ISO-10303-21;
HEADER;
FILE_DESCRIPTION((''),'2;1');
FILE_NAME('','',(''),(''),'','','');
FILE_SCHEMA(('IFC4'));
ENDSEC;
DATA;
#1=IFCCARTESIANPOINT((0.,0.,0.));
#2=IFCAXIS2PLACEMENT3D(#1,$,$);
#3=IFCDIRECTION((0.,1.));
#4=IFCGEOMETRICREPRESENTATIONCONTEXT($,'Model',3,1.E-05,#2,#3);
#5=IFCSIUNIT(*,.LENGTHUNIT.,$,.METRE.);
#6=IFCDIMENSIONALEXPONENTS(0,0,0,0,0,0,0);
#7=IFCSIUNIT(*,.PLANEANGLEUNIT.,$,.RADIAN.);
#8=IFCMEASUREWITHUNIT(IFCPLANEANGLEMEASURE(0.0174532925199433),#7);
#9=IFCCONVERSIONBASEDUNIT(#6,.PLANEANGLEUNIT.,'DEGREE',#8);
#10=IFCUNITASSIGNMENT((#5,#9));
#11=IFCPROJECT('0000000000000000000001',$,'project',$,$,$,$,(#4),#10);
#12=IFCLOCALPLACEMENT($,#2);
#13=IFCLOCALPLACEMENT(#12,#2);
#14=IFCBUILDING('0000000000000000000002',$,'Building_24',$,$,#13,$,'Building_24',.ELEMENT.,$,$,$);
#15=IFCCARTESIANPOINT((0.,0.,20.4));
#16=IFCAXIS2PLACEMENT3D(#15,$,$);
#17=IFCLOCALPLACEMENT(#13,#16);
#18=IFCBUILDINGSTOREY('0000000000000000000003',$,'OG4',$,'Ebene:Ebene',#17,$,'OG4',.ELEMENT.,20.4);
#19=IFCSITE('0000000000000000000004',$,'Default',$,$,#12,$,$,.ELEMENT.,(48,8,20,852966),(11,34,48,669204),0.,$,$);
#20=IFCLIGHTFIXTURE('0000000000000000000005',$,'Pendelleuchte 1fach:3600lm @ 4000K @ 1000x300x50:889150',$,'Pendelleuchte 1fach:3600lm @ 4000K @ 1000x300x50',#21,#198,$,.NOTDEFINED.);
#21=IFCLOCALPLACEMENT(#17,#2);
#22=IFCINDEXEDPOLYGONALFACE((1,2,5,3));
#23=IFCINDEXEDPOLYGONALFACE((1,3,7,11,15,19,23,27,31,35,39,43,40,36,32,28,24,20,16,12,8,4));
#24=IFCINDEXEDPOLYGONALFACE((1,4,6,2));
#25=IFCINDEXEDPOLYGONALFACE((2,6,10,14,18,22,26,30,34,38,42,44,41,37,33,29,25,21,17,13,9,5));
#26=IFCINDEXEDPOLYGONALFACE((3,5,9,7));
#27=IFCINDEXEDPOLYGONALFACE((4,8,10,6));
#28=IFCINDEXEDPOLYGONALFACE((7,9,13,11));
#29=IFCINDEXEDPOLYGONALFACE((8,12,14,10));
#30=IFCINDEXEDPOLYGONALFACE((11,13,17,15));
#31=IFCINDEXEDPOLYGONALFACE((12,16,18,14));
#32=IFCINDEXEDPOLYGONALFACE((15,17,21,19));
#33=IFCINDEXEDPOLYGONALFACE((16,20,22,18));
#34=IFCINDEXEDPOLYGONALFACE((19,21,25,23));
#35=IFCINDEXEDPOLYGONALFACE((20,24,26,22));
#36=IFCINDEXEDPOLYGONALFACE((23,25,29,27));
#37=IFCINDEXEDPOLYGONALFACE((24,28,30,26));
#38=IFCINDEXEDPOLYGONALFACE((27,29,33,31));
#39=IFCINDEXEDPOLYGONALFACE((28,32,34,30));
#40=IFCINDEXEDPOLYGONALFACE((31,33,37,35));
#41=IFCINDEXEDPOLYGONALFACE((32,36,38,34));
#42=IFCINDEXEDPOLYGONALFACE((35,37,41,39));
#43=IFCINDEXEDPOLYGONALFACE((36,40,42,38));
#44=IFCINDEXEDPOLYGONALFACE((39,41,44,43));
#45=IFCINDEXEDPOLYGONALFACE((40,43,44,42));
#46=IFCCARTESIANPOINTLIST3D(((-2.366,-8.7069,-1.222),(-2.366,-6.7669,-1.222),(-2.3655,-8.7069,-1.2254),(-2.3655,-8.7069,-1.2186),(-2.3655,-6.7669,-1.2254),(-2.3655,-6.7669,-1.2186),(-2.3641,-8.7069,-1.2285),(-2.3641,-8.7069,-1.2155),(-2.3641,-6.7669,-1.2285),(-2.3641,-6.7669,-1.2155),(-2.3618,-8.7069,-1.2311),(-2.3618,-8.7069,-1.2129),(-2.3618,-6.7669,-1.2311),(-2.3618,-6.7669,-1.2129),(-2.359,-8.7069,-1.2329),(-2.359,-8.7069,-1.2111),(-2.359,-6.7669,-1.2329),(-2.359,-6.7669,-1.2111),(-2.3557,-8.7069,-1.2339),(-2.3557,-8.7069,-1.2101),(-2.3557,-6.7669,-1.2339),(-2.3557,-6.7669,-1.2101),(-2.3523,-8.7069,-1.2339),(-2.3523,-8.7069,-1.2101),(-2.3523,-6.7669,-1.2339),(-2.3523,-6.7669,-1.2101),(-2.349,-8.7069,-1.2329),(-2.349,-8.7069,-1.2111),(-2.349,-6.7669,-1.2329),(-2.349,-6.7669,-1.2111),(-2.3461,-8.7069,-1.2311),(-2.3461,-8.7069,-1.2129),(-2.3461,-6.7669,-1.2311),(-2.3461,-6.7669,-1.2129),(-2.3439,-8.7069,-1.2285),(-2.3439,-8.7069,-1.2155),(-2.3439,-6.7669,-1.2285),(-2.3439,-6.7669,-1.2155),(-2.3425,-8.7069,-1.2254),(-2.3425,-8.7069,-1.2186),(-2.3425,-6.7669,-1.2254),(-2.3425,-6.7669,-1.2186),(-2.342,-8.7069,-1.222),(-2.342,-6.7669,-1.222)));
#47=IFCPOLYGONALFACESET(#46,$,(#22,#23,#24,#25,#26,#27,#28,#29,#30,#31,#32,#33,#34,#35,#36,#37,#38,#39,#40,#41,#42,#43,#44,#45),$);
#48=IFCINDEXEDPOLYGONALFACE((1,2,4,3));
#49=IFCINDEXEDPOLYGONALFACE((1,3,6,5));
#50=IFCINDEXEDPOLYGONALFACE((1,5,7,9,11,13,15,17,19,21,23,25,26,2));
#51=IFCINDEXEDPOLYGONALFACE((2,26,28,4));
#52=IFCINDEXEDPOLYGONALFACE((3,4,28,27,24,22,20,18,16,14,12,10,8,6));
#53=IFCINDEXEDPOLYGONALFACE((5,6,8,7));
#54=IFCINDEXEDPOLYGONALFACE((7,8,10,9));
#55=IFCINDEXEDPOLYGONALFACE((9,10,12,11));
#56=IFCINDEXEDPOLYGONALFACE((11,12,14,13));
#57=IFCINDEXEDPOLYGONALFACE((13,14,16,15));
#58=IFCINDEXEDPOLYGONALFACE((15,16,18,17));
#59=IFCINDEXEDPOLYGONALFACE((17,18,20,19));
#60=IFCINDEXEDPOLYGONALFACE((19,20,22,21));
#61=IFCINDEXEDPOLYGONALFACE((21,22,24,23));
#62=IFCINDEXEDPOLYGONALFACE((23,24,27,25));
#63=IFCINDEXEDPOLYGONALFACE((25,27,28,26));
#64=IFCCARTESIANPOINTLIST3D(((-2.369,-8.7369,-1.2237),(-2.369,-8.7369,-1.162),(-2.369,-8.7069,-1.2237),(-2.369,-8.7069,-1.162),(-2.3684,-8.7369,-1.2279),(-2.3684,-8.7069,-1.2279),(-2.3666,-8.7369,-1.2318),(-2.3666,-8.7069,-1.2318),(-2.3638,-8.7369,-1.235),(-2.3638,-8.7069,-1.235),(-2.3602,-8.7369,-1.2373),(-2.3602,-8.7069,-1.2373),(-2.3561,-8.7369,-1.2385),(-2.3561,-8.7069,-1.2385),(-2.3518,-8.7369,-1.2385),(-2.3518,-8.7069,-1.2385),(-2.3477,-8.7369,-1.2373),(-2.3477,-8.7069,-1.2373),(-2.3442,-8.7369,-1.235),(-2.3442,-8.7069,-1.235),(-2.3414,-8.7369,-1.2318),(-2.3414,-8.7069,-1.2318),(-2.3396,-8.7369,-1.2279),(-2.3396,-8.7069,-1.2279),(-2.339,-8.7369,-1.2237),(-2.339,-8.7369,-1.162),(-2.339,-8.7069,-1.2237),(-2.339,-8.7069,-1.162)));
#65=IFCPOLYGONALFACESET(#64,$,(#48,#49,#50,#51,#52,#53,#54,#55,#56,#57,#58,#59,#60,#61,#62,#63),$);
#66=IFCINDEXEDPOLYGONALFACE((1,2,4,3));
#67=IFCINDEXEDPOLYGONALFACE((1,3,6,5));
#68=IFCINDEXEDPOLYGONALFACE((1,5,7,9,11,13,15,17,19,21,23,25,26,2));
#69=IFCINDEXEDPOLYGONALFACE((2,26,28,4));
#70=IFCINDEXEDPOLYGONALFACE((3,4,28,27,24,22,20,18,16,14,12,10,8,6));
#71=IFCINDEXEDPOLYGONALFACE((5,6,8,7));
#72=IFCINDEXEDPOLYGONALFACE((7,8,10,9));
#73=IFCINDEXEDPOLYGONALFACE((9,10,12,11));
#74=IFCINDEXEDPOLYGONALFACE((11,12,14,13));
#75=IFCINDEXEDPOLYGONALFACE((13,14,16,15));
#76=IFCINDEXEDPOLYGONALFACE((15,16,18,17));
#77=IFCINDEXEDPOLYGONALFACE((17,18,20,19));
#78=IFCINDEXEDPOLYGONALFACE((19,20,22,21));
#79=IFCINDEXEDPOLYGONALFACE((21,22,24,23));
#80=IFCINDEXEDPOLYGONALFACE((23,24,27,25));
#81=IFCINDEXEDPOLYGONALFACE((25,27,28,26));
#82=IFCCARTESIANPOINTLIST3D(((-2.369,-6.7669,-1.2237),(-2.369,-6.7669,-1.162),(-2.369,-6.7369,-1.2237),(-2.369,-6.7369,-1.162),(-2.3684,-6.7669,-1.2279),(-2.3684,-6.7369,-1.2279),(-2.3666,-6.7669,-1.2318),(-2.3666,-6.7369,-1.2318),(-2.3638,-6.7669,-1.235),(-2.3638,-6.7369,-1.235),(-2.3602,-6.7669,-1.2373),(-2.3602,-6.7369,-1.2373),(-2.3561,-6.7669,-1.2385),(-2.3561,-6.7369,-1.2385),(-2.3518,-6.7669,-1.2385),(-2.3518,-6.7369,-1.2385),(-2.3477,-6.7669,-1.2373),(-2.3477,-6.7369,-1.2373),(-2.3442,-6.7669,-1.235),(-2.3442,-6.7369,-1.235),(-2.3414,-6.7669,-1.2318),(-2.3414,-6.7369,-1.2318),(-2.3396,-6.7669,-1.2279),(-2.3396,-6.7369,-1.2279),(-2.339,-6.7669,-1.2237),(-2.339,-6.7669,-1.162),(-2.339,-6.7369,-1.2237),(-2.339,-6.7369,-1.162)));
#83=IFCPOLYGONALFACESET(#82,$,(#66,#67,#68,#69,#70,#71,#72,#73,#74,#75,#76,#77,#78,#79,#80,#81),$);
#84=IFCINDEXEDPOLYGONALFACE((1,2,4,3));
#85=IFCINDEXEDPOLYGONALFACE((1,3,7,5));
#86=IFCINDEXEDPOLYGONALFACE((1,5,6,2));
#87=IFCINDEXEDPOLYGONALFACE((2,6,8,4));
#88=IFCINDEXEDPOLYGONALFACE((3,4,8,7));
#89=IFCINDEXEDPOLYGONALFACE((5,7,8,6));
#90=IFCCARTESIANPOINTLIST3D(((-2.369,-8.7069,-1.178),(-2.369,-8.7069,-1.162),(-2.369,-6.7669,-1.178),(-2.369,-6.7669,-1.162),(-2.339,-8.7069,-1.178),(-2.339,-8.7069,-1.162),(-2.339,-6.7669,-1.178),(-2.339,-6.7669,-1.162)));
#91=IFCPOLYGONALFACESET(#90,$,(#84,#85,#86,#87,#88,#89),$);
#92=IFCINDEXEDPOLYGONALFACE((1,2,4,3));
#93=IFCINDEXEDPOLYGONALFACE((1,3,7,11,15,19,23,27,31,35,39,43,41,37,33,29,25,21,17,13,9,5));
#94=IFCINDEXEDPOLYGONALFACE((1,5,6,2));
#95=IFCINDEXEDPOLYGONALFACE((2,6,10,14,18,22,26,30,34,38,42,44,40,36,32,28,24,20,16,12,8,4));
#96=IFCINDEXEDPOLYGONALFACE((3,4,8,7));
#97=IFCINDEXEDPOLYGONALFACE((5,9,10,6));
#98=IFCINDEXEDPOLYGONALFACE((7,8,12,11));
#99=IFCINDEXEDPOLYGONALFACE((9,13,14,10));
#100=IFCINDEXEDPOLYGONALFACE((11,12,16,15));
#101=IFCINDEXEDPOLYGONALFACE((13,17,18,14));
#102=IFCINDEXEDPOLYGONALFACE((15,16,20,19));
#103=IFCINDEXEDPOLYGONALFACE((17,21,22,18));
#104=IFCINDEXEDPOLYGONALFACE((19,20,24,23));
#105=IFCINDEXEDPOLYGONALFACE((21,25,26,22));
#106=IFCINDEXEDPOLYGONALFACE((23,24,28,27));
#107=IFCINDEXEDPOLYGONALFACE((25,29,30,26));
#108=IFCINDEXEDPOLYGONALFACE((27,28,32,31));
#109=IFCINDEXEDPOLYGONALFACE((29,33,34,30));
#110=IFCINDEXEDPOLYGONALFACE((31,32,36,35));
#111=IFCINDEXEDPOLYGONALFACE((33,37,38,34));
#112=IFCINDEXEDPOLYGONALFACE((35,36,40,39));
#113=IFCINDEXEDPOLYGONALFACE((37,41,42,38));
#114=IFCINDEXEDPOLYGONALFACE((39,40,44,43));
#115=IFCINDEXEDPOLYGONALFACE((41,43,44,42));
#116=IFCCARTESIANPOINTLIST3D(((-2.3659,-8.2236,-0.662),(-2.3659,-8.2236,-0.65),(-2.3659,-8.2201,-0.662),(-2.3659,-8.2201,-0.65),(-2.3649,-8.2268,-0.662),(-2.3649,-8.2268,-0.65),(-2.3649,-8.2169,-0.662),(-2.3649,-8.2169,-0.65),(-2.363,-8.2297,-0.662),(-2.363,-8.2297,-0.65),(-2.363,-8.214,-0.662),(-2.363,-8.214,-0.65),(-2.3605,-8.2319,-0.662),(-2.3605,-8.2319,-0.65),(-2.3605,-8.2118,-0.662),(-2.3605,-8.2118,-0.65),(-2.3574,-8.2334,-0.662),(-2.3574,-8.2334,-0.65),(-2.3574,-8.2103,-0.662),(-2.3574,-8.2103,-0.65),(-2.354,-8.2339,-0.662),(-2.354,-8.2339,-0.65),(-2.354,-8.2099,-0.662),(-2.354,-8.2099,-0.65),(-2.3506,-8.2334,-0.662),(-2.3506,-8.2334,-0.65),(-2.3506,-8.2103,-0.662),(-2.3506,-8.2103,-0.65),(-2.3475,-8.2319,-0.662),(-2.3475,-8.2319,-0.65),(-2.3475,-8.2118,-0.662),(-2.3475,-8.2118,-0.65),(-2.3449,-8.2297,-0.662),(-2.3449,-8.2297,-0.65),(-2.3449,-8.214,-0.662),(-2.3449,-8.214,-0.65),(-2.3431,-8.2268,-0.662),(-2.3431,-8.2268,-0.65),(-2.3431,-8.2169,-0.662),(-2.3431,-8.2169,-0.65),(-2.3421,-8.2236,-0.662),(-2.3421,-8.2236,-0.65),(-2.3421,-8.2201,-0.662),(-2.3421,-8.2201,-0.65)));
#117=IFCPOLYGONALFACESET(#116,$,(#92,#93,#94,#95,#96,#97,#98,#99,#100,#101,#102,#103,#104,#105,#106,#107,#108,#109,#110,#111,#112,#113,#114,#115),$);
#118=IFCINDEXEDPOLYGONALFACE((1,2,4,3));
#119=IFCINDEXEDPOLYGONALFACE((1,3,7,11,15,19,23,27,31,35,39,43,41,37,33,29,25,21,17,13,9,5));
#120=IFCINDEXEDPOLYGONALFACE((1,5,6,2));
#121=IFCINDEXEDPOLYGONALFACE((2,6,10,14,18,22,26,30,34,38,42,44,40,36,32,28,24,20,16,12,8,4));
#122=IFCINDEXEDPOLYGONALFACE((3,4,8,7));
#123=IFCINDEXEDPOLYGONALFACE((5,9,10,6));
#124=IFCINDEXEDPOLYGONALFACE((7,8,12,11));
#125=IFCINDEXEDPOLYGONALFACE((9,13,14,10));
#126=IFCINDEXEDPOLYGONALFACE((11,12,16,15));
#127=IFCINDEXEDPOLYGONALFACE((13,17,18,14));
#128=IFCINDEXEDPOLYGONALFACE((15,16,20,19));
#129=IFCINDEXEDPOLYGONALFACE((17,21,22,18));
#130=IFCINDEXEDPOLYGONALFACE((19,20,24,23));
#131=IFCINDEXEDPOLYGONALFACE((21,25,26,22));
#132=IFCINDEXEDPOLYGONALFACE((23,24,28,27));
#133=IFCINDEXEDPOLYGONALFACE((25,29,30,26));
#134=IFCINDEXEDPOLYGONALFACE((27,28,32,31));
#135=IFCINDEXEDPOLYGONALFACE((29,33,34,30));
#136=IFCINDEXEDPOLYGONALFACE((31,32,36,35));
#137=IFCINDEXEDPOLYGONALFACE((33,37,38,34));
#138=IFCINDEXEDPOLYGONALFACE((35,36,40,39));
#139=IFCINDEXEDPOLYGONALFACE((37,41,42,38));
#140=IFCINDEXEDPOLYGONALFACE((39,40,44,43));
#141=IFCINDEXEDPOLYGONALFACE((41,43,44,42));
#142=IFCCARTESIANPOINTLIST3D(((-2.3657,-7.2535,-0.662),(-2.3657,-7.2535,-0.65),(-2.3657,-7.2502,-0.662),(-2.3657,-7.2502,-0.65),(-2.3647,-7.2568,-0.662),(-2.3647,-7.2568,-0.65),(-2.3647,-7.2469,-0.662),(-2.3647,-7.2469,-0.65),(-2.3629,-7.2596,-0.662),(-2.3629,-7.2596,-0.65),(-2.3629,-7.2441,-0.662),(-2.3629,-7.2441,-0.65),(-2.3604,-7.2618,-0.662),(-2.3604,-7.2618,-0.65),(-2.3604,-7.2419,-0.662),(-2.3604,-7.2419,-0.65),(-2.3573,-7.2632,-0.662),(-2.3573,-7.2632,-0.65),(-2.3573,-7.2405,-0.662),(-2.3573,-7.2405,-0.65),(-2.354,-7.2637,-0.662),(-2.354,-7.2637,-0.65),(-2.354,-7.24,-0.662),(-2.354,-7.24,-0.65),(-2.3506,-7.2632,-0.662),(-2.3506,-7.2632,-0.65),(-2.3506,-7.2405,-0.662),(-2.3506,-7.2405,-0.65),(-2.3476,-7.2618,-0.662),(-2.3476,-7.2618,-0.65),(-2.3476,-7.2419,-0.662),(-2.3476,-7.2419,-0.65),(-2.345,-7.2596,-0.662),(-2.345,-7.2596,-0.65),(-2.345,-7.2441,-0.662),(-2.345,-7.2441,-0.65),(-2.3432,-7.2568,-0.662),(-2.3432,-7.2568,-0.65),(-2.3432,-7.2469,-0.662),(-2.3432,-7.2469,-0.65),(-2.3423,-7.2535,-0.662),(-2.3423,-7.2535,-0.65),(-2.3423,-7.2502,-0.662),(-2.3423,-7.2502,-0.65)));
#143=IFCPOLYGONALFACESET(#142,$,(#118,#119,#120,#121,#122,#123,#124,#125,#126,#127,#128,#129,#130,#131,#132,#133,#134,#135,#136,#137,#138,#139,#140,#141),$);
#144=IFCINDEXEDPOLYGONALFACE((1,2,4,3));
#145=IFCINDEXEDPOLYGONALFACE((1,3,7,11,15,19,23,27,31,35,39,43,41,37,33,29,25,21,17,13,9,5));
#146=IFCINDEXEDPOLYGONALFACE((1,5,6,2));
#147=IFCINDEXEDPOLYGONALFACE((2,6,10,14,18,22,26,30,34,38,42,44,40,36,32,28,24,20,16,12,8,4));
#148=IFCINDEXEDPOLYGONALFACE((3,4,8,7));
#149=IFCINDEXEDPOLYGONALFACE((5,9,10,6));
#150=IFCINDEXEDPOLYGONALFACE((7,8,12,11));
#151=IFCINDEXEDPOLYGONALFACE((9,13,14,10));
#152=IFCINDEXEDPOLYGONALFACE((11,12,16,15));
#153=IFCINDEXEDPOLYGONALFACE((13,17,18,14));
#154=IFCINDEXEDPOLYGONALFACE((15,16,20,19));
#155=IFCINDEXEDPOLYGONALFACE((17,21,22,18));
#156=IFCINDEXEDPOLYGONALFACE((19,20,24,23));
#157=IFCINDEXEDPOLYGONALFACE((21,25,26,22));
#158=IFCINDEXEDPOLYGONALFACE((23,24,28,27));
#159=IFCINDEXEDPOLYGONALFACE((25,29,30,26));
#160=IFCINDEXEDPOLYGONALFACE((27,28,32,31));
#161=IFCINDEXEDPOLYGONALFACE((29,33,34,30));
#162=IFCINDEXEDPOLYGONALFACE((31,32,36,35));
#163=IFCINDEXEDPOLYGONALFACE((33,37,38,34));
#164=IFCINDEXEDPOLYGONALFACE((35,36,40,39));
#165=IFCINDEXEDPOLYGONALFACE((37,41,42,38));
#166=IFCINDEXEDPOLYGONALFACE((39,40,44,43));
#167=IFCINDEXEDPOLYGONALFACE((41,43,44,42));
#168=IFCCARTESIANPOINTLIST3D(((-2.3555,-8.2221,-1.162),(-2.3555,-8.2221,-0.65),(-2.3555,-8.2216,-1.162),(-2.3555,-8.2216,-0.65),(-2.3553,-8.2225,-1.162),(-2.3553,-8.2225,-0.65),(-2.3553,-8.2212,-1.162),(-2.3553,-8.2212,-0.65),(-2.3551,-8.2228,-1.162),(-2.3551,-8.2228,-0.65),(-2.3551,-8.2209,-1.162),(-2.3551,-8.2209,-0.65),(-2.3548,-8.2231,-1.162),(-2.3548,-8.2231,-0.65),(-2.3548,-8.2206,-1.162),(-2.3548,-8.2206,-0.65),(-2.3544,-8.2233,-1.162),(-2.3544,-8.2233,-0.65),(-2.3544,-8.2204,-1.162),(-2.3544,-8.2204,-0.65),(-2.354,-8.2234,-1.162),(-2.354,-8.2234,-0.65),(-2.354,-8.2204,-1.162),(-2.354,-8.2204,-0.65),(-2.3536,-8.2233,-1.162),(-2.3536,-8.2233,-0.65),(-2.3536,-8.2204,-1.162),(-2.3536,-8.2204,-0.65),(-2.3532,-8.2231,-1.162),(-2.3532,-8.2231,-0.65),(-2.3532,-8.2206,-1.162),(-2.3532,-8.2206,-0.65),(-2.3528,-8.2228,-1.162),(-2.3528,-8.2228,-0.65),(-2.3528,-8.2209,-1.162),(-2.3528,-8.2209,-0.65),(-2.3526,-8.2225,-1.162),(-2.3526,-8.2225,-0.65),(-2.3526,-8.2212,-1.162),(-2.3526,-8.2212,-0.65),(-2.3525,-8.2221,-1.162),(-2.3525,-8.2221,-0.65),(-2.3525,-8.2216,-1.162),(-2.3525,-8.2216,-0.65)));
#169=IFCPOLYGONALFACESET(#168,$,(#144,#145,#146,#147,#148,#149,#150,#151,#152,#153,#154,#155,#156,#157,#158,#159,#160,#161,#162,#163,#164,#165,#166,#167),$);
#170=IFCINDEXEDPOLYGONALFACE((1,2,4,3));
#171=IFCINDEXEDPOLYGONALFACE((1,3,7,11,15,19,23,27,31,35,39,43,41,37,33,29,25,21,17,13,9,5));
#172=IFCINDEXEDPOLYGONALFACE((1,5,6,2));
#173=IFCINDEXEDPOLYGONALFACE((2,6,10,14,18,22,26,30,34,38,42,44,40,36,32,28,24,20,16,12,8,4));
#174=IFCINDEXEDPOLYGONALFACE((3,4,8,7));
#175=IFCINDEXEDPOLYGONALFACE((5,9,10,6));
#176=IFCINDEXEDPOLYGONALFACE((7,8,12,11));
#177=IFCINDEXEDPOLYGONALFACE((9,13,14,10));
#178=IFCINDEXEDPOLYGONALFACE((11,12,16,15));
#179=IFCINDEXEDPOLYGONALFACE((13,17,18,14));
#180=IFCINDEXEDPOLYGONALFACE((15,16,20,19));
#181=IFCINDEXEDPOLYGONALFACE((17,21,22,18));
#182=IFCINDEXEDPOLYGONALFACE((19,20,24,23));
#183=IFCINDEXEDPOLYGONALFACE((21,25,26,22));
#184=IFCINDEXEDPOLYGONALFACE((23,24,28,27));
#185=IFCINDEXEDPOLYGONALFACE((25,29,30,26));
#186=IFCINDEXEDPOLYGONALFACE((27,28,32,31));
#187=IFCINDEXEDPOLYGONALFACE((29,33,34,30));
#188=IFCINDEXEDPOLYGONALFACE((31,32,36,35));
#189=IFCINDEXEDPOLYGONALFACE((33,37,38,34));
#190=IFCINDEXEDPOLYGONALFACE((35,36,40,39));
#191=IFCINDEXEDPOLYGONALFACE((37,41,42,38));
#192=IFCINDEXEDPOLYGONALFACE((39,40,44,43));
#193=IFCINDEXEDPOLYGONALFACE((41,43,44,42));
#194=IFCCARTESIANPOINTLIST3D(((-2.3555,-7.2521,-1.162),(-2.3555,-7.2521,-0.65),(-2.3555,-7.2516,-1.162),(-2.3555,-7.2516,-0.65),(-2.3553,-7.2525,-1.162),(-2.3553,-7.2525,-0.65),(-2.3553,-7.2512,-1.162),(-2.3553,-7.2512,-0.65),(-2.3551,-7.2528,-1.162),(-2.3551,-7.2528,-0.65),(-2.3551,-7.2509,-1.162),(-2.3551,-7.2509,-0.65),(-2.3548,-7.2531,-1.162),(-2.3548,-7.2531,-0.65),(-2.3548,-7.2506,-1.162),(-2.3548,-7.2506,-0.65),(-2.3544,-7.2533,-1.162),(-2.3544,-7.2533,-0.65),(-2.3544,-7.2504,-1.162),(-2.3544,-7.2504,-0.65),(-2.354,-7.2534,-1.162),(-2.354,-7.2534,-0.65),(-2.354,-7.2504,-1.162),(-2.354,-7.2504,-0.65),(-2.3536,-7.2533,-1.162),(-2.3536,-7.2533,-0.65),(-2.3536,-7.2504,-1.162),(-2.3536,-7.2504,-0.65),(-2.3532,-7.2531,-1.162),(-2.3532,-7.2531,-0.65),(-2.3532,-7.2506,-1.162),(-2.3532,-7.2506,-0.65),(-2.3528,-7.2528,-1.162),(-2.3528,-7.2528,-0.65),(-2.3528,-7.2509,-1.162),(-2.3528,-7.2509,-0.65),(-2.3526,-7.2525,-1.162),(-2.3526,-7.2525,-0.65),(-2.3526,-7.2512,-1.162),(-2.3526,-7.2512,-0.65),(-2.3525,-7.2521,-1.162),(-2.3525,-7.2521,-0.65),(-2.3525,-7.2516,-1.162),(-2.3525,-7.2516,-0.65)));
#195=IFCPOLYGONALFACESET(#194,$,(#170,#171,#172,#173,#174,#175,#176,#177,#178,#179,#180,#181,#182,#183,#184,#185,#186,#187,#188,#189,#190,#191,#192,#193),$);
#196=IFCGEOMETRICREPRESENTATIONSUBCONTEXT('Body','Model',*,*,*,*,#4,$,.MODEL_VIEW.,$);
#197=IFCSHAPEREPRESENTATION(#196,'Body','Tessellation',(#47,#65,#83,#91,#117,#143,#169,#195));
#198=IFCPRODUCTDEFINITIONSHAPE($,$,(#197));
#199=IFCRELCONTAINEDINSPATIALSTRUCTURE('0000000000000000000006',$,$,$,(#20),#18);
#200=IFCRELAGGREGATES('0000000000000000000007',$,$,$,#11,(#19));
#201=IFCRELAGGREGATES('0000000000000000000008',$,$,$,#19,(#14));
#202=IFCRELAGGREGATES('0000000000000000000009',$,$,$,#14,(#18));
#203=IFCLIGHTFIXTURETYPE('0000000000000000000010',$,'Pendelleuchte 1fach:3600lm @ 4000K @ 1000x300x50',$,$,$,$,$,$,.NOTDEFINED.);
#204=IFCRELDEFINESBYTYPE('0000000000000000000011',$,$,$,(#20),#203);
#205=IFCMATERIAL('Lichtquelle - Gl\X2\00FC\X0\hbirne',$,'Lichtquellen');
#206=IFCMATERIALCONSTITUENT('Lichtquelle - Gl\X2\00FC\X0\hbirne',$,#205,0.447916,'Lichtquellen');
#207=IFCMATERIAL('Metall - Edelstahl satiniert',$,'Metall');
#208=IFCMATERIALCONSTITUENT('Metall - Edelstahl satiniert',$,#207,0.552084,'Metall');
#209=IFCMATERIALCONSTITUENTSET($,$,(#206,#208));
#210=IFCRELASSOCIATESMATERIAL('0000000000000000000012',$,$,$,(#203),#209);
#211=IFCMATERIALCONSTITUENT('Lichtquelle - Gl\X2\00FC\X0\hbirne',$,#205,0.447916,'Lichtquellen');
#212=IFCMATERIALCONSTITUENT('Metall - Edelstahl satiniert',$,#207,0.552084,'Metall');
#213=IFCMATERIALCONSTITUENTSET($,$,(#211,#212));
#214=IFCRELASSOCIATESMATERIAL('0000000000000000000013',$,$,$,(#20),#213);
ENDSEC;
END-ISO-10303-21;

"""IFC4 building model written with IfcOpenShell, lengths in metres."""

from ifc_helpers import new_model, entity, si_unit, converted_unit, direction, frame, origin, place, context, subcontext, project, spatial, line, arc, indexed_curve, outline, extrude, source, transform, mapped, material, constituent, constituent_set, type_object, type_shapes, element, save


model = new_model("IFC4")

# Units and contexts
model_context = context("Model", 3, precision=1e-05, world=origin(), true_north=direction((0.0, 1.0)))
body_context = subcontext(model_context, "Body", "Model", "MODEL_VIEW")
ifc_project = project(units=[si_unit("LENGTHUNIT", "METRE"), converted_unit("PLANEANGLEUNIT", "DEGREE", entity("IfcPlaneAngleMeasure", 0.0174532925199433), si_unit("PLANEANGLEUNIT", "RADIAN"), dimensions=[0, 0, 0, 0, 0, 0, 0])], contexts=[model_context])

# Site, building, storey
site_placement = place(None, origin())
site = spatial("IfcSite", under=ifc_project, at=site_placement, Name="Default", CompositionType="ELEMENT", RefLatitude=(48, 8, 20, 852966), RefLongitude=(11, 34, 48, 669204), RefElevation=0.0)
building_placement = place(site_placement, origin())
building = spatial("IfcBuilding", under=site, at=building_placement, Name="Building_24", LongName="Building_24", CompositionType="ELEMENT")
storey_placement = place(building_placement, frame((0.0, 0.0, 20.4)))
storey = spatial("IfcBuildingStorey", under=building, at=storey_placement, Name="OG4", ObjectType="Ebene:Ebene", LongName="OG4", CompositionType="ELEMENT", Elevation=20.4)

# Light fixture
ifc_material_1 = material(Name="Lichtquelle - Glühbirne", Category="Lichtquellen")
ifc_constituent_1 = constituent(ifc_material_1, Name="Lichtquelle - Glühbirne", Category="Lichtquellen", fraction=0.447916)
ifc_material_2 = material(Name="Metall - Edelstahl satiniert", Category="Metall")
ifc_constituent_2 = constituent(ifc_material_2, Name="Metall - Edelstahl satiniert", Category="Metall", fraction=0.552084)
ifc_constituent_set_1 = constituent_set(constituents=[ifc_constituent_1, ifc_constituent_2])
ifc_constituent_3 = constituent(ifc_material_1, Name="Lichtquelle - Glühbirne", Category="Lichtquellen", fraction=0.447916)
ifc_constituent_4 = constituent(ifc_material_2, Name="Metall - Edelstahl satiniert", Category="Metall", fraction=0.552084)
ifc_constituent_set_2 = constituent_set(constituents=[ifc_constituent_3, ifc_constituent_4])
light_fixture_type = type_object("IfcLightFixtureType", Name="Pendelleuchte 1fach:3600lm @ 4000K @ 1000x300x50", PredefinedType="NOTDEFINED", material=ifc_constituent_set_2)
shared_shape_1 = source(origin(), body_context, "Body", "SweptSolid", [
    extrude(outline(indexed_curve([(-0.012, 0.0), (0.0, -0.012), (0.012, 0.0), (0.0, 0.012)], segments=[arc(1, 2, 3), arc(3, 4, 1)], self_intersect=False)), frame((-0.97, 0.0, -0.572), z_axis=(1.0, 0.0, 0.0), x_axis=(0.0, 1.0, 0.0)), (0.0, 0.0, 1.0), 1.94),
    extrude(outline(indexed_curve([(-0.0308, -0.015), (0.0308, -0.015), (0.0308, 0.015), (-0.0308, 0.015), (-0.0458, 0.0)], segments=[line(1, 2, 3, 4), arc(4, 5, 1)], self_intersect=False)), frame((0.97, 0.0, -0.5428), z_axis=(1.0, 0.0, 0.0), x_axis=(0.0, 0.0, 1.0)), (0.0, 0.0, 1.0), 0.03),
    extrude(outline(indexed_curve([(-0.0308, -0.015), (0.0308, -0.015), (0.0308, 0.015), (-0.0308, 0.015), (-0.0458, 0.0)], segments=[line(1, 2, 3, 4), arc(4, 5, 1)], self_intersect=False)), frame((-1.0, 0.0, -0.5428), z_axis=(1.0, 0.0, 0.0), x_axis=(0.0, 0.0, 1.0)), (0.0, 0.0, 1.0), 0.03),
    extrude(outline(indexed_curve([(-0.97, -0.015), (0.97, -0.015), (0.97, 0.015), (-0.97, 0.015), (-0.97, -0.015)], self_intersect=False)), frame((0.0, 0.0, -0.528), z_axis=(0.0, 0.0, 1.0), x_axis=(-1.0, 0.0, 0.0)), (0.0, 0.0, 1.0), 0.016),
    extrude(outline(indexed_curve([(-0.012, 0.0), (0.0, -0.012), (0.012, 0.0), (0.0, 0.012)], segments=[arc(1, 2, 3), arc(3, 4, 1)], self_intersect=False)), frame((0.485, 0.0, -0.012)), (0.0, 0.0, 1.0), 0.012),
    extrude(outline(indexed_curve([(-0.0118, 0.0), (0.0, -0.0118), (0.0118, 0.0), (0.0, 0.0118)], segments=[arc(1, 2, 3), arc(3, 4, 1)], self_intersect=False)), frame((-0.485, 0.0, -0.012)), (0.0, 0.0, 1.0), 0.012),
    extrude(outline(indexed_curve([(-0.0015, 0.0), (0.0, -0.0015), (0.0015, 0.0), (0.0, 0.0015)], segments=[arc(1, 2, 3), arc(3, 4, 1)], self_intersect=False)), frame((0.485, 0.0, -0.512)), (0.0, 0.0, 1.0), 0.512),
    extrude(outline(indexed_curve([(-0.0015, 0.0), (0.0, -0.0015), (0.0015, 0.0), (0.0, 0.0015)], segments=[arc(1, 2, 3), arc(3, 4, 1)], self_intersect=False)), frame((-0.485, 0.0, -0.512)), (0.0, 0.0, 1.0), 0.512),
])
type_shapes(light_fixture_type, [shared_shape_1])
light_fixture_1_placement = place(storey_placement, frame((-2.354, -7.7369, -0.65), z_axis=(0.0, 0.0, 1.0), x_axis=(0.0, -1.0, 0.0)))
element("IfcLightFixture", 1, at=light_fixture_1_placement, inside=storey, type_object=light_fixture_type, material=ifc_constituent_set_1, Name="Pendelleuchte 1fach:3600lm @ 4000K @ 1000x300x50:889150", ObjectType="Pendelleuchte 1fach:3600lm @ 4000K @ 1000x300x50", PredefinedType="NOTDEFINED", context=body_context, shape_type="MappedRepresentation", body=[
    mapped(shared_shape_1, transform((0.0, 0.0, 0.0), scale=1.0)),
])

save(model, "model.ifc")
